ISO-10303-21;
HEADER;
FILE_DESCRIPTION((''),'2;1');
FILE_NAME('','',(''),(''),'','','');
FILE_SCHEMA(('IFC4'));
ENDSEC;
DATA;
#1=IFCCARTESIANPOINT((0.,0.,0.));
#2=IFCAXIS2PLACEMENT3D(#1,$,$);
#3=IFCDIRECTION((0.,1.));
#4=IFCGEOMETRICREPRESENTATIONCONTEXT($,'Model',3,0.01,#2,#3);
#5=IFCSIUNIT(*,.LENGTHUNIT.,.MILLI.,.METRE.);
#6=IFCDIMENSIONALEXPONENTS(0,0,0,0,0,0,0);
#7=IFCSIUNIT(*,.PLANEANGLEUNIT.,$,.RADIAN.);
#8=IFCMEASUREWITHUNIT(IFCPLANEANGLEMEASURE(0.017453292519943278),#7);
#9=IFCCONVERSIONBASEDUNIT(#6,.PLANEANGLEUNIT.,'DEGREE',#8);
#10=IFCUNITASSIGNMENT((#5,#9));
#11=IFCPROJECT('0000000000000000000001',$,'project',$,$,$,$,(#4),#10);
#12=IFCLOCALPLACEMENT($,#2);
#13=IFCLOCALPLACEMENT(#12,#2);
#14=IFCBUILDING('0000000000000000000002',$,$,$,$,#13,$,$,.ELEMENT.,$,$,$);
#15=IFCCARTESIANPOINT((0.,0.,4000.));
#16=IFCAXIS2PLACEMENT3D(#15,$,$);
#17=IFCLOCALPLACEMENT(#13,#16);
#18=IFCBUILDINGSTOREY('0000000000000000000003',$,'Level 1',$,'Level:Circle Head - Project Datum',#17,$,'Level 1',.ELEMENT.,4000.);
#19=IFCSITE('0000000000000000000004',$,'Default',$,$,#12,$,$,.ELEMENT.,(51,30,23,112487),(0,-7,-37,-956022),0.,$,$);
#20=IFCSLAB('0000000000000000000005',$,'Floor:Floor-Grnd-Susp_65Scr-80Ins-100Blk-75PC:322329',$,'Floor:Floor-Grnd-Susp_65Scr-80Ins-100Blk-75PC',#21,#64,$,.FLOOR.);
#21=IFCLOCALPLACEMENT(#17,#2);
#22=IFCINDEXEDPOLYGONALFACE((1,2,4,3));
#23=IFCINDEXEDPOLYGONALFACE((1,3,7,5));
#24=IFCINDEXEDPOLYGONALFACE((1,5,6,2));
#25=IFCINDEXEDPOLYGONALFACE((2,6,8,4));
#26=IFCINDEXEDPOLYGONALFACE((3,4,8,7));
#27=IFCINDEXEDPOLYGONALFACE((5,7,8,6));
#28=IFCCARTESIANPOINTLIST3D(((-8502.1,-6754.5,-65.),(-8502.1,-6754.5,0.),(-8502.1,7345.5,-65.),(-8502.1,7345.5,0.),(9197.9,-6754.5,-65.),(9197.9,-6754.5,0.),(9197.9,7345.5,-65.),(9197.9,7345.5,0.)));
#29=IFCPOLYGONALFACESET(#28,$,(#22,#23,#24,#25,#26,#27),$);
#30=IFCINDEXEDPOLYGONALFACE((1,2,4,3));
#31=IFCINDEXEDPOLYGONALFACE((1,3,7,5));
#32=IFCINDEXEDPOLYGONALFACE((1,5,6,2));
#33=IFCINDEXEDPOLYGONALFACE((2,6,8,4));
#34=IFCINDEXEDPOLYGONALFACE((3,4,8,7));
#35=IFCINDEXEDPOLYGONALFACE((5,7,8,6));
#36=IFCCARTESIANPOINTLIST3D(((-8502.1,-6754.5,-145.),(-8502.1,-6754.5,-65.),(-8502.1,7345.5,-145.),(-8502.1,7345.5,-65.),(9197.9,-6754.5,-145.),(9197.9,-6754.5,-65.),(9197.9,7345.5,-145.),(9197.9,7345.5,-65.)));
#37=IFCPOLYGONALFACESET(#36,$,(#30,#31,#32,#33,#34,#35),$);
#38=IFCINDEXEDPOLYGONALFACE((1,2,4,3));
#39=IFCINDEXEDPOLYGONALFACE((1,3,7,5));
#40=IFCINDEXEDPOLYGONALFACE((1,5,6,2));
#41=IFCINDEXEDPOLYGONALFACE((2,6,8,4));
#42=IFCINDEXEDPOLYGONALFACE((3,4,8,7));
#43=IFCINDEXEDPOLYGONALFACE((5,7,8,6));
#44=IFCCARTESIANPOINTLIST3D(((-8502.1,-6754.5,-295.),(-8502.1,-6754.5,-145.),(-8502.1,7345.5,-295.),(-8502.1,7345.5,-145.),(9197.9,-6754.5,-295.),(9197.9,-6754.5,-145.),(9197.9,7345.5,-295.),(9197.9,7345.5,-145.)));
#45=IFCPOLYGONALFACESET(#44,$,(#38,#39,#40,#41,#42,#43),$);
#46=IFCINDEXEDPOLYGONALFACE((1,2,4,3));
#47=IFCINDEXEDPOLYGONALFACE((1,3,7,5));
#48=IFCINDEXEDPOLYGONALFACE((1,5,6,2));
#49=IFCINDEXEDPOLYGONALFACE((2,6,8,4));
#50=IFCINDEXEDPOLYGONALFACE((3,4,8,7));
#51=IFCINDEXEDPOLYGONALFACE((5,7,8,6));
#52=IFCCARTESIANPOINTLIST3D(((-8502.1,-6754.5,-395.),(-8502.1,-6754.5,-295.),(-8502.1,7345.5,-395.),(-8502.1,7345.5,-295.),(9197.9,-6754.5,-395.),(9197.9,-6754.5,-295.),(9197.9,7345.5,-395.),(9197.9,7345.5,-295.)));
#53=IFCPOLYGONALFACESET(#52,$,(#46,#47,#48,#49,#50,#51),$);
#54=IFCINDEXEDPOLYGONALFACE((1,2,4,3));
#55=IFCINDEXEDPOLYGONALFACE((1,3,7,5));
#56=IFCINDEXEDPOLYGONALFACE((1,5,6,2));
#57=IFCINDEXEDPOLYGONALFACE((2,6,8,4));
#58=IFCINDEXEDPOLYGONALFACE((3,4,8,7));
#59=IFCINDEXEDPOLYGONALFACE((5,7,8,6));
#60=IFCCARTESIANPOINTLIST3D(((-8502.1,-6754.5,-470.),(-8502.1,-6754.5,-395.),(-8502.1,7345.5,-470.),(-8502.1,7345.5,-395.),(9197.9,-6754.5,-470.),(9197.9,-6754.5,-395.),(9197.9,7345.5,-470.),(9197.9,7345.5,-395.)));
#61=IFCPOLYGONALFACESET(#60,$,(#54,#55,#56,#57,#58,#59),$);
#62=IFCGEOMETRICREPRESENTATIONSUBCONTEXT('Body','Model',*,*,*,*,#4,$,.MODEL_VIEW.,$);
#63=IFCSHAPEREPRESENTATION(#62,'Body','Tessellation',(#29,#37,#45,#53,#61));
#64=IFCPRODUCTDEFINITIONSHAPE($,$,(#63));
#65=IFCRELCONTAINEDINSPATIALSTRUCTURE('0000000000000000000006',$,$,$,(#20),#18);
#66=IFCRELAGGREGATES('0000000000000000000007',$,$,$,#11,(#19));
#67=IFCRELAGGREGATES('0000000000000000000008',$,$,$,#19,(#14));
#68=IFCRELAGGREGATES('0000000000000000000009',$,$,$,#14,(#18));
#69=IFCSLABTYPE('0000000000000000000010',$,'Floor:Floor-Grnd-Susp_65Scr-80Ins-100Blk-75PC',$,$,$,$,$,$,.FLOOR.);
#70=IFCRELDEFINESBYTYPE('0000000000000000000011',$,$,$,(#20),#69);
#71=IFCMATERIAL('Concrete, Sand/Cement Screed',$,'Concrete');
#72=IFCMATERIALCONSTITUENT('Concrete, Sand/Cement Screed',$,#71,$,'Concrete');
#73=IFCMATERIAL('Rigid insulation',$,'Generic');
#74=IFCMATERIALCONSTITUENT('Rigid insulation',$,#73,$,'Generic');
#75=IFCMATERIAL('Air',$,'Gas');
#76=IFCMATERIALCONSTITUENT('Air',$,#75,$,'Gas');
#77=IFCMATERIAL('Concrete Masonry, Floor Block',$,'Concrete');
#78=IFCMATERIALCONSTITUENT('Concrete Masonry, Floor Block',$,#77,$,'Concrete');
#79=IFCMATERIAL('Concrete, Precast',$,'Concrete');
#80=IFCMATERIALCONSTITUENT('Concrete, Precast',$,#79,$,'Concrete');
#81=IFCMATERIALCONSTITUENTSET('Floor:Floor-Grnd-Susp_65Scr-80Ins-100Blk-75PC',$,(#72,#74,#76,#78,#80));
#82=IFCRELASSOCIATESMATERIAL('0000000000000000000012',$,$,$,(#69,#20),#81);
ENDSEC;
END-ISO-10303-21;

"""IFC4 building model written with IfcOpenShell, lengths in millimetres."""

from ifc_helpers import new_model, entity, si_unit, converted_unit, direction, frame, origin, place, context, subcontext, project, spatial, indexed_curve, outline, extrude, material, constituent, constituent_set, type_object, element, save


model = new_model("IFC4")

# Units and contexts
model_context = context("Model", 3, precision=0.01, world=origin(), true_north=direction((0.0, 1.0)))
body_context = subcontext(model_context, "Body", "Model", "MODEL_VIEW")
ifc_project = project(units=[si_unit("LENGTHUNIT", "METRE", prefix="MILLI"), converted_unit("PLANEANGLEUNIT", "DEGREE", entity("IfcPlaneAngleMeasure", 0.017453292519943278), si_unit("PLANEANGLEUNIT", "RADIAN"), dimensions=[0, 0, 0, 0, 0, 0, 0])], contexts=[model_context])

# Site, building, storey
site_placement = place(None, origin())
site = spatial("IfcSite", under=ifc_project, at=site_placement, Name="Default", CompositionType="ELEMENT", RefLatitude=(51, 30, 23, 112487), RefLongitude=(0, -7, -37, -956022), RefElevation=0.0)
building_placement = place(site_placement, origin())
building = spatial("IfcBuilding", under=site, at=building_placement, CompositionType="ELEMENT")
storey_placement = place(building_placement, frame((0.0, 0.0, 4000.0)))
storey = spatial("IfcBuildingStorey", under=building, at=storey_placement, Name="Level 1", ObjectType="Level:Circle Head - Project Datum", LongName="Level 1", CompositionType="ELEMENT", Elevation=4000.0)

# Slab
ifc_material_1 = material(Name="Concrete, Sand/Cement Screed", Category="Concrete")
ifc_constituent_1 = constituent(ifc_material_1, Name="Concrete, Sand/Cement Screed", Category="Concrete")
ifc_material_2 = material(Name="Rigid insulation", Category="Generic")
ifc_constituent_2 = constituent(ifc_material_2, Name="Rigid insulation", Category="Generic")
ifc_material_3 = material(Name="Air", Category="Gas")
ifc_constituent_3 = constituent(ifc_material_3, Name="Air", Category="Gas")
ifc_material_4 = material(Name="Concrete Masonry, Floor Block", Category="Concrete")
ifc_constituent_4 = constituent(ifc_material_4, Name="Concrete Masonry, Floor Block", Category="Concrete")
ifc_material_5 = material(Name="Concrete, Precast", Category="Concrete")
ifc_constituent_5 = constituent(ifc_material_5, Name="Concrete, Precast", Category="Concrete")
ifc_constituent_set = constituent_set(constituents=[ifc_constituent_1, ifc_constituent_2, ifc_constituent_3, ifc_constituent_4, ifc_constituent_5], Name="Floor:Floor-Grnd-Susp_65Scr-80Ins-100Blk-75PC")
slab_type = type_object("IfcSlabType", Name="Floor:Floor-Grnd-Susp_65Scr-80Ins-100Blk-75PC", PredefinedType="FLOOR", material=ifc_constituent_set)
slab_placement = place(storey_placement, origin())
element("IfcSlab", 1, at=slab_placement, inside=storey, type_object=slab_type, material=ifc_constituent_set, Name="Floor:Floor-Grnd-Susp_65Scr-80Ins-100Blk-75PC:322329", ObjectType="Floor:Floor-Grnd-Susp_65Scr-80Ins-100Blk-75PC", PredefinedType="FLOOR", context=body_context, shape_type="SweptSolid", body=[
    extrude(outline(indexed_curve([(-8850.0, -7050.0), (8850.0, -7050.0), (8850.0, 7050.0), (-8850.0, 7050.0), (-8850.0, -7050.0)], self_intersect=False)), frame((347.9, 295.5, -65.0), z_axis=(0.0, 0.0, 1.0), x_axis=(-1.0, 0.0, 0.0)), (0.0, 0.0, 1.0), 65.0),
    extrude(outline(indexed_curve([(-8850.0, -7050.0), (8850.0, -7050.0), (8850.0, 7050.0), (-8850.0, 7050.0), (-8850.0, -7050.0)], self_intersect=False)), frame((347.9, 295.5, -145.0), z_axis=(0.0, 0.0, 1.0), x_axis=(-1.0, 0.0, 0.0)), (0.0, 0.0, 1.0), 80.0),
    extrude(outline(indexed_curve([(-8850.0, -7050.0), (8850.0, -7050.0), (8850.0, 7050.0), (-8850.0, 7050.0), (-8850.0, -7050.0)], self_intersect=False)), frame((347.9, 295.5, -295.0), z_axis=(0.0, 0.0, 1.0), x_axis=(-1.0, 0.0, 0.0)), (0.0, 0.0, 1.0), 150.0),
    extrude(outline(indexed_curve([(-8850.0, -7050.0), (8850.0, -7050.0), (8850.0, 7050.0), (-8850.0, 7050.0), (-8850.0, -7050.0)], self_intersect=False)), frame((347.9, 295.5, -395.0), z_axis=(0.0, 0.0, 1.0), x_axis=(-1.0, 0.0, 0.0)), (0.0, 0.0, 1.0), 100.0),
    extrude(outline(indexed_curve([(-8850.0, -7050.0), (8850.0, -7050.0), (8850.0, 7050.0), (-8850.0, 7050.0), (-8850.0, -7050.0)], self_intersect=False)), frame((347.9, 295.5, -470.0), z_axis=(0.0, 0.0, 1.0), x_axis=(-1.0, 0.0, 0.0)), (0.0, 0.0, 1.0), 75.0),
])

save(model, "model.ifc")
